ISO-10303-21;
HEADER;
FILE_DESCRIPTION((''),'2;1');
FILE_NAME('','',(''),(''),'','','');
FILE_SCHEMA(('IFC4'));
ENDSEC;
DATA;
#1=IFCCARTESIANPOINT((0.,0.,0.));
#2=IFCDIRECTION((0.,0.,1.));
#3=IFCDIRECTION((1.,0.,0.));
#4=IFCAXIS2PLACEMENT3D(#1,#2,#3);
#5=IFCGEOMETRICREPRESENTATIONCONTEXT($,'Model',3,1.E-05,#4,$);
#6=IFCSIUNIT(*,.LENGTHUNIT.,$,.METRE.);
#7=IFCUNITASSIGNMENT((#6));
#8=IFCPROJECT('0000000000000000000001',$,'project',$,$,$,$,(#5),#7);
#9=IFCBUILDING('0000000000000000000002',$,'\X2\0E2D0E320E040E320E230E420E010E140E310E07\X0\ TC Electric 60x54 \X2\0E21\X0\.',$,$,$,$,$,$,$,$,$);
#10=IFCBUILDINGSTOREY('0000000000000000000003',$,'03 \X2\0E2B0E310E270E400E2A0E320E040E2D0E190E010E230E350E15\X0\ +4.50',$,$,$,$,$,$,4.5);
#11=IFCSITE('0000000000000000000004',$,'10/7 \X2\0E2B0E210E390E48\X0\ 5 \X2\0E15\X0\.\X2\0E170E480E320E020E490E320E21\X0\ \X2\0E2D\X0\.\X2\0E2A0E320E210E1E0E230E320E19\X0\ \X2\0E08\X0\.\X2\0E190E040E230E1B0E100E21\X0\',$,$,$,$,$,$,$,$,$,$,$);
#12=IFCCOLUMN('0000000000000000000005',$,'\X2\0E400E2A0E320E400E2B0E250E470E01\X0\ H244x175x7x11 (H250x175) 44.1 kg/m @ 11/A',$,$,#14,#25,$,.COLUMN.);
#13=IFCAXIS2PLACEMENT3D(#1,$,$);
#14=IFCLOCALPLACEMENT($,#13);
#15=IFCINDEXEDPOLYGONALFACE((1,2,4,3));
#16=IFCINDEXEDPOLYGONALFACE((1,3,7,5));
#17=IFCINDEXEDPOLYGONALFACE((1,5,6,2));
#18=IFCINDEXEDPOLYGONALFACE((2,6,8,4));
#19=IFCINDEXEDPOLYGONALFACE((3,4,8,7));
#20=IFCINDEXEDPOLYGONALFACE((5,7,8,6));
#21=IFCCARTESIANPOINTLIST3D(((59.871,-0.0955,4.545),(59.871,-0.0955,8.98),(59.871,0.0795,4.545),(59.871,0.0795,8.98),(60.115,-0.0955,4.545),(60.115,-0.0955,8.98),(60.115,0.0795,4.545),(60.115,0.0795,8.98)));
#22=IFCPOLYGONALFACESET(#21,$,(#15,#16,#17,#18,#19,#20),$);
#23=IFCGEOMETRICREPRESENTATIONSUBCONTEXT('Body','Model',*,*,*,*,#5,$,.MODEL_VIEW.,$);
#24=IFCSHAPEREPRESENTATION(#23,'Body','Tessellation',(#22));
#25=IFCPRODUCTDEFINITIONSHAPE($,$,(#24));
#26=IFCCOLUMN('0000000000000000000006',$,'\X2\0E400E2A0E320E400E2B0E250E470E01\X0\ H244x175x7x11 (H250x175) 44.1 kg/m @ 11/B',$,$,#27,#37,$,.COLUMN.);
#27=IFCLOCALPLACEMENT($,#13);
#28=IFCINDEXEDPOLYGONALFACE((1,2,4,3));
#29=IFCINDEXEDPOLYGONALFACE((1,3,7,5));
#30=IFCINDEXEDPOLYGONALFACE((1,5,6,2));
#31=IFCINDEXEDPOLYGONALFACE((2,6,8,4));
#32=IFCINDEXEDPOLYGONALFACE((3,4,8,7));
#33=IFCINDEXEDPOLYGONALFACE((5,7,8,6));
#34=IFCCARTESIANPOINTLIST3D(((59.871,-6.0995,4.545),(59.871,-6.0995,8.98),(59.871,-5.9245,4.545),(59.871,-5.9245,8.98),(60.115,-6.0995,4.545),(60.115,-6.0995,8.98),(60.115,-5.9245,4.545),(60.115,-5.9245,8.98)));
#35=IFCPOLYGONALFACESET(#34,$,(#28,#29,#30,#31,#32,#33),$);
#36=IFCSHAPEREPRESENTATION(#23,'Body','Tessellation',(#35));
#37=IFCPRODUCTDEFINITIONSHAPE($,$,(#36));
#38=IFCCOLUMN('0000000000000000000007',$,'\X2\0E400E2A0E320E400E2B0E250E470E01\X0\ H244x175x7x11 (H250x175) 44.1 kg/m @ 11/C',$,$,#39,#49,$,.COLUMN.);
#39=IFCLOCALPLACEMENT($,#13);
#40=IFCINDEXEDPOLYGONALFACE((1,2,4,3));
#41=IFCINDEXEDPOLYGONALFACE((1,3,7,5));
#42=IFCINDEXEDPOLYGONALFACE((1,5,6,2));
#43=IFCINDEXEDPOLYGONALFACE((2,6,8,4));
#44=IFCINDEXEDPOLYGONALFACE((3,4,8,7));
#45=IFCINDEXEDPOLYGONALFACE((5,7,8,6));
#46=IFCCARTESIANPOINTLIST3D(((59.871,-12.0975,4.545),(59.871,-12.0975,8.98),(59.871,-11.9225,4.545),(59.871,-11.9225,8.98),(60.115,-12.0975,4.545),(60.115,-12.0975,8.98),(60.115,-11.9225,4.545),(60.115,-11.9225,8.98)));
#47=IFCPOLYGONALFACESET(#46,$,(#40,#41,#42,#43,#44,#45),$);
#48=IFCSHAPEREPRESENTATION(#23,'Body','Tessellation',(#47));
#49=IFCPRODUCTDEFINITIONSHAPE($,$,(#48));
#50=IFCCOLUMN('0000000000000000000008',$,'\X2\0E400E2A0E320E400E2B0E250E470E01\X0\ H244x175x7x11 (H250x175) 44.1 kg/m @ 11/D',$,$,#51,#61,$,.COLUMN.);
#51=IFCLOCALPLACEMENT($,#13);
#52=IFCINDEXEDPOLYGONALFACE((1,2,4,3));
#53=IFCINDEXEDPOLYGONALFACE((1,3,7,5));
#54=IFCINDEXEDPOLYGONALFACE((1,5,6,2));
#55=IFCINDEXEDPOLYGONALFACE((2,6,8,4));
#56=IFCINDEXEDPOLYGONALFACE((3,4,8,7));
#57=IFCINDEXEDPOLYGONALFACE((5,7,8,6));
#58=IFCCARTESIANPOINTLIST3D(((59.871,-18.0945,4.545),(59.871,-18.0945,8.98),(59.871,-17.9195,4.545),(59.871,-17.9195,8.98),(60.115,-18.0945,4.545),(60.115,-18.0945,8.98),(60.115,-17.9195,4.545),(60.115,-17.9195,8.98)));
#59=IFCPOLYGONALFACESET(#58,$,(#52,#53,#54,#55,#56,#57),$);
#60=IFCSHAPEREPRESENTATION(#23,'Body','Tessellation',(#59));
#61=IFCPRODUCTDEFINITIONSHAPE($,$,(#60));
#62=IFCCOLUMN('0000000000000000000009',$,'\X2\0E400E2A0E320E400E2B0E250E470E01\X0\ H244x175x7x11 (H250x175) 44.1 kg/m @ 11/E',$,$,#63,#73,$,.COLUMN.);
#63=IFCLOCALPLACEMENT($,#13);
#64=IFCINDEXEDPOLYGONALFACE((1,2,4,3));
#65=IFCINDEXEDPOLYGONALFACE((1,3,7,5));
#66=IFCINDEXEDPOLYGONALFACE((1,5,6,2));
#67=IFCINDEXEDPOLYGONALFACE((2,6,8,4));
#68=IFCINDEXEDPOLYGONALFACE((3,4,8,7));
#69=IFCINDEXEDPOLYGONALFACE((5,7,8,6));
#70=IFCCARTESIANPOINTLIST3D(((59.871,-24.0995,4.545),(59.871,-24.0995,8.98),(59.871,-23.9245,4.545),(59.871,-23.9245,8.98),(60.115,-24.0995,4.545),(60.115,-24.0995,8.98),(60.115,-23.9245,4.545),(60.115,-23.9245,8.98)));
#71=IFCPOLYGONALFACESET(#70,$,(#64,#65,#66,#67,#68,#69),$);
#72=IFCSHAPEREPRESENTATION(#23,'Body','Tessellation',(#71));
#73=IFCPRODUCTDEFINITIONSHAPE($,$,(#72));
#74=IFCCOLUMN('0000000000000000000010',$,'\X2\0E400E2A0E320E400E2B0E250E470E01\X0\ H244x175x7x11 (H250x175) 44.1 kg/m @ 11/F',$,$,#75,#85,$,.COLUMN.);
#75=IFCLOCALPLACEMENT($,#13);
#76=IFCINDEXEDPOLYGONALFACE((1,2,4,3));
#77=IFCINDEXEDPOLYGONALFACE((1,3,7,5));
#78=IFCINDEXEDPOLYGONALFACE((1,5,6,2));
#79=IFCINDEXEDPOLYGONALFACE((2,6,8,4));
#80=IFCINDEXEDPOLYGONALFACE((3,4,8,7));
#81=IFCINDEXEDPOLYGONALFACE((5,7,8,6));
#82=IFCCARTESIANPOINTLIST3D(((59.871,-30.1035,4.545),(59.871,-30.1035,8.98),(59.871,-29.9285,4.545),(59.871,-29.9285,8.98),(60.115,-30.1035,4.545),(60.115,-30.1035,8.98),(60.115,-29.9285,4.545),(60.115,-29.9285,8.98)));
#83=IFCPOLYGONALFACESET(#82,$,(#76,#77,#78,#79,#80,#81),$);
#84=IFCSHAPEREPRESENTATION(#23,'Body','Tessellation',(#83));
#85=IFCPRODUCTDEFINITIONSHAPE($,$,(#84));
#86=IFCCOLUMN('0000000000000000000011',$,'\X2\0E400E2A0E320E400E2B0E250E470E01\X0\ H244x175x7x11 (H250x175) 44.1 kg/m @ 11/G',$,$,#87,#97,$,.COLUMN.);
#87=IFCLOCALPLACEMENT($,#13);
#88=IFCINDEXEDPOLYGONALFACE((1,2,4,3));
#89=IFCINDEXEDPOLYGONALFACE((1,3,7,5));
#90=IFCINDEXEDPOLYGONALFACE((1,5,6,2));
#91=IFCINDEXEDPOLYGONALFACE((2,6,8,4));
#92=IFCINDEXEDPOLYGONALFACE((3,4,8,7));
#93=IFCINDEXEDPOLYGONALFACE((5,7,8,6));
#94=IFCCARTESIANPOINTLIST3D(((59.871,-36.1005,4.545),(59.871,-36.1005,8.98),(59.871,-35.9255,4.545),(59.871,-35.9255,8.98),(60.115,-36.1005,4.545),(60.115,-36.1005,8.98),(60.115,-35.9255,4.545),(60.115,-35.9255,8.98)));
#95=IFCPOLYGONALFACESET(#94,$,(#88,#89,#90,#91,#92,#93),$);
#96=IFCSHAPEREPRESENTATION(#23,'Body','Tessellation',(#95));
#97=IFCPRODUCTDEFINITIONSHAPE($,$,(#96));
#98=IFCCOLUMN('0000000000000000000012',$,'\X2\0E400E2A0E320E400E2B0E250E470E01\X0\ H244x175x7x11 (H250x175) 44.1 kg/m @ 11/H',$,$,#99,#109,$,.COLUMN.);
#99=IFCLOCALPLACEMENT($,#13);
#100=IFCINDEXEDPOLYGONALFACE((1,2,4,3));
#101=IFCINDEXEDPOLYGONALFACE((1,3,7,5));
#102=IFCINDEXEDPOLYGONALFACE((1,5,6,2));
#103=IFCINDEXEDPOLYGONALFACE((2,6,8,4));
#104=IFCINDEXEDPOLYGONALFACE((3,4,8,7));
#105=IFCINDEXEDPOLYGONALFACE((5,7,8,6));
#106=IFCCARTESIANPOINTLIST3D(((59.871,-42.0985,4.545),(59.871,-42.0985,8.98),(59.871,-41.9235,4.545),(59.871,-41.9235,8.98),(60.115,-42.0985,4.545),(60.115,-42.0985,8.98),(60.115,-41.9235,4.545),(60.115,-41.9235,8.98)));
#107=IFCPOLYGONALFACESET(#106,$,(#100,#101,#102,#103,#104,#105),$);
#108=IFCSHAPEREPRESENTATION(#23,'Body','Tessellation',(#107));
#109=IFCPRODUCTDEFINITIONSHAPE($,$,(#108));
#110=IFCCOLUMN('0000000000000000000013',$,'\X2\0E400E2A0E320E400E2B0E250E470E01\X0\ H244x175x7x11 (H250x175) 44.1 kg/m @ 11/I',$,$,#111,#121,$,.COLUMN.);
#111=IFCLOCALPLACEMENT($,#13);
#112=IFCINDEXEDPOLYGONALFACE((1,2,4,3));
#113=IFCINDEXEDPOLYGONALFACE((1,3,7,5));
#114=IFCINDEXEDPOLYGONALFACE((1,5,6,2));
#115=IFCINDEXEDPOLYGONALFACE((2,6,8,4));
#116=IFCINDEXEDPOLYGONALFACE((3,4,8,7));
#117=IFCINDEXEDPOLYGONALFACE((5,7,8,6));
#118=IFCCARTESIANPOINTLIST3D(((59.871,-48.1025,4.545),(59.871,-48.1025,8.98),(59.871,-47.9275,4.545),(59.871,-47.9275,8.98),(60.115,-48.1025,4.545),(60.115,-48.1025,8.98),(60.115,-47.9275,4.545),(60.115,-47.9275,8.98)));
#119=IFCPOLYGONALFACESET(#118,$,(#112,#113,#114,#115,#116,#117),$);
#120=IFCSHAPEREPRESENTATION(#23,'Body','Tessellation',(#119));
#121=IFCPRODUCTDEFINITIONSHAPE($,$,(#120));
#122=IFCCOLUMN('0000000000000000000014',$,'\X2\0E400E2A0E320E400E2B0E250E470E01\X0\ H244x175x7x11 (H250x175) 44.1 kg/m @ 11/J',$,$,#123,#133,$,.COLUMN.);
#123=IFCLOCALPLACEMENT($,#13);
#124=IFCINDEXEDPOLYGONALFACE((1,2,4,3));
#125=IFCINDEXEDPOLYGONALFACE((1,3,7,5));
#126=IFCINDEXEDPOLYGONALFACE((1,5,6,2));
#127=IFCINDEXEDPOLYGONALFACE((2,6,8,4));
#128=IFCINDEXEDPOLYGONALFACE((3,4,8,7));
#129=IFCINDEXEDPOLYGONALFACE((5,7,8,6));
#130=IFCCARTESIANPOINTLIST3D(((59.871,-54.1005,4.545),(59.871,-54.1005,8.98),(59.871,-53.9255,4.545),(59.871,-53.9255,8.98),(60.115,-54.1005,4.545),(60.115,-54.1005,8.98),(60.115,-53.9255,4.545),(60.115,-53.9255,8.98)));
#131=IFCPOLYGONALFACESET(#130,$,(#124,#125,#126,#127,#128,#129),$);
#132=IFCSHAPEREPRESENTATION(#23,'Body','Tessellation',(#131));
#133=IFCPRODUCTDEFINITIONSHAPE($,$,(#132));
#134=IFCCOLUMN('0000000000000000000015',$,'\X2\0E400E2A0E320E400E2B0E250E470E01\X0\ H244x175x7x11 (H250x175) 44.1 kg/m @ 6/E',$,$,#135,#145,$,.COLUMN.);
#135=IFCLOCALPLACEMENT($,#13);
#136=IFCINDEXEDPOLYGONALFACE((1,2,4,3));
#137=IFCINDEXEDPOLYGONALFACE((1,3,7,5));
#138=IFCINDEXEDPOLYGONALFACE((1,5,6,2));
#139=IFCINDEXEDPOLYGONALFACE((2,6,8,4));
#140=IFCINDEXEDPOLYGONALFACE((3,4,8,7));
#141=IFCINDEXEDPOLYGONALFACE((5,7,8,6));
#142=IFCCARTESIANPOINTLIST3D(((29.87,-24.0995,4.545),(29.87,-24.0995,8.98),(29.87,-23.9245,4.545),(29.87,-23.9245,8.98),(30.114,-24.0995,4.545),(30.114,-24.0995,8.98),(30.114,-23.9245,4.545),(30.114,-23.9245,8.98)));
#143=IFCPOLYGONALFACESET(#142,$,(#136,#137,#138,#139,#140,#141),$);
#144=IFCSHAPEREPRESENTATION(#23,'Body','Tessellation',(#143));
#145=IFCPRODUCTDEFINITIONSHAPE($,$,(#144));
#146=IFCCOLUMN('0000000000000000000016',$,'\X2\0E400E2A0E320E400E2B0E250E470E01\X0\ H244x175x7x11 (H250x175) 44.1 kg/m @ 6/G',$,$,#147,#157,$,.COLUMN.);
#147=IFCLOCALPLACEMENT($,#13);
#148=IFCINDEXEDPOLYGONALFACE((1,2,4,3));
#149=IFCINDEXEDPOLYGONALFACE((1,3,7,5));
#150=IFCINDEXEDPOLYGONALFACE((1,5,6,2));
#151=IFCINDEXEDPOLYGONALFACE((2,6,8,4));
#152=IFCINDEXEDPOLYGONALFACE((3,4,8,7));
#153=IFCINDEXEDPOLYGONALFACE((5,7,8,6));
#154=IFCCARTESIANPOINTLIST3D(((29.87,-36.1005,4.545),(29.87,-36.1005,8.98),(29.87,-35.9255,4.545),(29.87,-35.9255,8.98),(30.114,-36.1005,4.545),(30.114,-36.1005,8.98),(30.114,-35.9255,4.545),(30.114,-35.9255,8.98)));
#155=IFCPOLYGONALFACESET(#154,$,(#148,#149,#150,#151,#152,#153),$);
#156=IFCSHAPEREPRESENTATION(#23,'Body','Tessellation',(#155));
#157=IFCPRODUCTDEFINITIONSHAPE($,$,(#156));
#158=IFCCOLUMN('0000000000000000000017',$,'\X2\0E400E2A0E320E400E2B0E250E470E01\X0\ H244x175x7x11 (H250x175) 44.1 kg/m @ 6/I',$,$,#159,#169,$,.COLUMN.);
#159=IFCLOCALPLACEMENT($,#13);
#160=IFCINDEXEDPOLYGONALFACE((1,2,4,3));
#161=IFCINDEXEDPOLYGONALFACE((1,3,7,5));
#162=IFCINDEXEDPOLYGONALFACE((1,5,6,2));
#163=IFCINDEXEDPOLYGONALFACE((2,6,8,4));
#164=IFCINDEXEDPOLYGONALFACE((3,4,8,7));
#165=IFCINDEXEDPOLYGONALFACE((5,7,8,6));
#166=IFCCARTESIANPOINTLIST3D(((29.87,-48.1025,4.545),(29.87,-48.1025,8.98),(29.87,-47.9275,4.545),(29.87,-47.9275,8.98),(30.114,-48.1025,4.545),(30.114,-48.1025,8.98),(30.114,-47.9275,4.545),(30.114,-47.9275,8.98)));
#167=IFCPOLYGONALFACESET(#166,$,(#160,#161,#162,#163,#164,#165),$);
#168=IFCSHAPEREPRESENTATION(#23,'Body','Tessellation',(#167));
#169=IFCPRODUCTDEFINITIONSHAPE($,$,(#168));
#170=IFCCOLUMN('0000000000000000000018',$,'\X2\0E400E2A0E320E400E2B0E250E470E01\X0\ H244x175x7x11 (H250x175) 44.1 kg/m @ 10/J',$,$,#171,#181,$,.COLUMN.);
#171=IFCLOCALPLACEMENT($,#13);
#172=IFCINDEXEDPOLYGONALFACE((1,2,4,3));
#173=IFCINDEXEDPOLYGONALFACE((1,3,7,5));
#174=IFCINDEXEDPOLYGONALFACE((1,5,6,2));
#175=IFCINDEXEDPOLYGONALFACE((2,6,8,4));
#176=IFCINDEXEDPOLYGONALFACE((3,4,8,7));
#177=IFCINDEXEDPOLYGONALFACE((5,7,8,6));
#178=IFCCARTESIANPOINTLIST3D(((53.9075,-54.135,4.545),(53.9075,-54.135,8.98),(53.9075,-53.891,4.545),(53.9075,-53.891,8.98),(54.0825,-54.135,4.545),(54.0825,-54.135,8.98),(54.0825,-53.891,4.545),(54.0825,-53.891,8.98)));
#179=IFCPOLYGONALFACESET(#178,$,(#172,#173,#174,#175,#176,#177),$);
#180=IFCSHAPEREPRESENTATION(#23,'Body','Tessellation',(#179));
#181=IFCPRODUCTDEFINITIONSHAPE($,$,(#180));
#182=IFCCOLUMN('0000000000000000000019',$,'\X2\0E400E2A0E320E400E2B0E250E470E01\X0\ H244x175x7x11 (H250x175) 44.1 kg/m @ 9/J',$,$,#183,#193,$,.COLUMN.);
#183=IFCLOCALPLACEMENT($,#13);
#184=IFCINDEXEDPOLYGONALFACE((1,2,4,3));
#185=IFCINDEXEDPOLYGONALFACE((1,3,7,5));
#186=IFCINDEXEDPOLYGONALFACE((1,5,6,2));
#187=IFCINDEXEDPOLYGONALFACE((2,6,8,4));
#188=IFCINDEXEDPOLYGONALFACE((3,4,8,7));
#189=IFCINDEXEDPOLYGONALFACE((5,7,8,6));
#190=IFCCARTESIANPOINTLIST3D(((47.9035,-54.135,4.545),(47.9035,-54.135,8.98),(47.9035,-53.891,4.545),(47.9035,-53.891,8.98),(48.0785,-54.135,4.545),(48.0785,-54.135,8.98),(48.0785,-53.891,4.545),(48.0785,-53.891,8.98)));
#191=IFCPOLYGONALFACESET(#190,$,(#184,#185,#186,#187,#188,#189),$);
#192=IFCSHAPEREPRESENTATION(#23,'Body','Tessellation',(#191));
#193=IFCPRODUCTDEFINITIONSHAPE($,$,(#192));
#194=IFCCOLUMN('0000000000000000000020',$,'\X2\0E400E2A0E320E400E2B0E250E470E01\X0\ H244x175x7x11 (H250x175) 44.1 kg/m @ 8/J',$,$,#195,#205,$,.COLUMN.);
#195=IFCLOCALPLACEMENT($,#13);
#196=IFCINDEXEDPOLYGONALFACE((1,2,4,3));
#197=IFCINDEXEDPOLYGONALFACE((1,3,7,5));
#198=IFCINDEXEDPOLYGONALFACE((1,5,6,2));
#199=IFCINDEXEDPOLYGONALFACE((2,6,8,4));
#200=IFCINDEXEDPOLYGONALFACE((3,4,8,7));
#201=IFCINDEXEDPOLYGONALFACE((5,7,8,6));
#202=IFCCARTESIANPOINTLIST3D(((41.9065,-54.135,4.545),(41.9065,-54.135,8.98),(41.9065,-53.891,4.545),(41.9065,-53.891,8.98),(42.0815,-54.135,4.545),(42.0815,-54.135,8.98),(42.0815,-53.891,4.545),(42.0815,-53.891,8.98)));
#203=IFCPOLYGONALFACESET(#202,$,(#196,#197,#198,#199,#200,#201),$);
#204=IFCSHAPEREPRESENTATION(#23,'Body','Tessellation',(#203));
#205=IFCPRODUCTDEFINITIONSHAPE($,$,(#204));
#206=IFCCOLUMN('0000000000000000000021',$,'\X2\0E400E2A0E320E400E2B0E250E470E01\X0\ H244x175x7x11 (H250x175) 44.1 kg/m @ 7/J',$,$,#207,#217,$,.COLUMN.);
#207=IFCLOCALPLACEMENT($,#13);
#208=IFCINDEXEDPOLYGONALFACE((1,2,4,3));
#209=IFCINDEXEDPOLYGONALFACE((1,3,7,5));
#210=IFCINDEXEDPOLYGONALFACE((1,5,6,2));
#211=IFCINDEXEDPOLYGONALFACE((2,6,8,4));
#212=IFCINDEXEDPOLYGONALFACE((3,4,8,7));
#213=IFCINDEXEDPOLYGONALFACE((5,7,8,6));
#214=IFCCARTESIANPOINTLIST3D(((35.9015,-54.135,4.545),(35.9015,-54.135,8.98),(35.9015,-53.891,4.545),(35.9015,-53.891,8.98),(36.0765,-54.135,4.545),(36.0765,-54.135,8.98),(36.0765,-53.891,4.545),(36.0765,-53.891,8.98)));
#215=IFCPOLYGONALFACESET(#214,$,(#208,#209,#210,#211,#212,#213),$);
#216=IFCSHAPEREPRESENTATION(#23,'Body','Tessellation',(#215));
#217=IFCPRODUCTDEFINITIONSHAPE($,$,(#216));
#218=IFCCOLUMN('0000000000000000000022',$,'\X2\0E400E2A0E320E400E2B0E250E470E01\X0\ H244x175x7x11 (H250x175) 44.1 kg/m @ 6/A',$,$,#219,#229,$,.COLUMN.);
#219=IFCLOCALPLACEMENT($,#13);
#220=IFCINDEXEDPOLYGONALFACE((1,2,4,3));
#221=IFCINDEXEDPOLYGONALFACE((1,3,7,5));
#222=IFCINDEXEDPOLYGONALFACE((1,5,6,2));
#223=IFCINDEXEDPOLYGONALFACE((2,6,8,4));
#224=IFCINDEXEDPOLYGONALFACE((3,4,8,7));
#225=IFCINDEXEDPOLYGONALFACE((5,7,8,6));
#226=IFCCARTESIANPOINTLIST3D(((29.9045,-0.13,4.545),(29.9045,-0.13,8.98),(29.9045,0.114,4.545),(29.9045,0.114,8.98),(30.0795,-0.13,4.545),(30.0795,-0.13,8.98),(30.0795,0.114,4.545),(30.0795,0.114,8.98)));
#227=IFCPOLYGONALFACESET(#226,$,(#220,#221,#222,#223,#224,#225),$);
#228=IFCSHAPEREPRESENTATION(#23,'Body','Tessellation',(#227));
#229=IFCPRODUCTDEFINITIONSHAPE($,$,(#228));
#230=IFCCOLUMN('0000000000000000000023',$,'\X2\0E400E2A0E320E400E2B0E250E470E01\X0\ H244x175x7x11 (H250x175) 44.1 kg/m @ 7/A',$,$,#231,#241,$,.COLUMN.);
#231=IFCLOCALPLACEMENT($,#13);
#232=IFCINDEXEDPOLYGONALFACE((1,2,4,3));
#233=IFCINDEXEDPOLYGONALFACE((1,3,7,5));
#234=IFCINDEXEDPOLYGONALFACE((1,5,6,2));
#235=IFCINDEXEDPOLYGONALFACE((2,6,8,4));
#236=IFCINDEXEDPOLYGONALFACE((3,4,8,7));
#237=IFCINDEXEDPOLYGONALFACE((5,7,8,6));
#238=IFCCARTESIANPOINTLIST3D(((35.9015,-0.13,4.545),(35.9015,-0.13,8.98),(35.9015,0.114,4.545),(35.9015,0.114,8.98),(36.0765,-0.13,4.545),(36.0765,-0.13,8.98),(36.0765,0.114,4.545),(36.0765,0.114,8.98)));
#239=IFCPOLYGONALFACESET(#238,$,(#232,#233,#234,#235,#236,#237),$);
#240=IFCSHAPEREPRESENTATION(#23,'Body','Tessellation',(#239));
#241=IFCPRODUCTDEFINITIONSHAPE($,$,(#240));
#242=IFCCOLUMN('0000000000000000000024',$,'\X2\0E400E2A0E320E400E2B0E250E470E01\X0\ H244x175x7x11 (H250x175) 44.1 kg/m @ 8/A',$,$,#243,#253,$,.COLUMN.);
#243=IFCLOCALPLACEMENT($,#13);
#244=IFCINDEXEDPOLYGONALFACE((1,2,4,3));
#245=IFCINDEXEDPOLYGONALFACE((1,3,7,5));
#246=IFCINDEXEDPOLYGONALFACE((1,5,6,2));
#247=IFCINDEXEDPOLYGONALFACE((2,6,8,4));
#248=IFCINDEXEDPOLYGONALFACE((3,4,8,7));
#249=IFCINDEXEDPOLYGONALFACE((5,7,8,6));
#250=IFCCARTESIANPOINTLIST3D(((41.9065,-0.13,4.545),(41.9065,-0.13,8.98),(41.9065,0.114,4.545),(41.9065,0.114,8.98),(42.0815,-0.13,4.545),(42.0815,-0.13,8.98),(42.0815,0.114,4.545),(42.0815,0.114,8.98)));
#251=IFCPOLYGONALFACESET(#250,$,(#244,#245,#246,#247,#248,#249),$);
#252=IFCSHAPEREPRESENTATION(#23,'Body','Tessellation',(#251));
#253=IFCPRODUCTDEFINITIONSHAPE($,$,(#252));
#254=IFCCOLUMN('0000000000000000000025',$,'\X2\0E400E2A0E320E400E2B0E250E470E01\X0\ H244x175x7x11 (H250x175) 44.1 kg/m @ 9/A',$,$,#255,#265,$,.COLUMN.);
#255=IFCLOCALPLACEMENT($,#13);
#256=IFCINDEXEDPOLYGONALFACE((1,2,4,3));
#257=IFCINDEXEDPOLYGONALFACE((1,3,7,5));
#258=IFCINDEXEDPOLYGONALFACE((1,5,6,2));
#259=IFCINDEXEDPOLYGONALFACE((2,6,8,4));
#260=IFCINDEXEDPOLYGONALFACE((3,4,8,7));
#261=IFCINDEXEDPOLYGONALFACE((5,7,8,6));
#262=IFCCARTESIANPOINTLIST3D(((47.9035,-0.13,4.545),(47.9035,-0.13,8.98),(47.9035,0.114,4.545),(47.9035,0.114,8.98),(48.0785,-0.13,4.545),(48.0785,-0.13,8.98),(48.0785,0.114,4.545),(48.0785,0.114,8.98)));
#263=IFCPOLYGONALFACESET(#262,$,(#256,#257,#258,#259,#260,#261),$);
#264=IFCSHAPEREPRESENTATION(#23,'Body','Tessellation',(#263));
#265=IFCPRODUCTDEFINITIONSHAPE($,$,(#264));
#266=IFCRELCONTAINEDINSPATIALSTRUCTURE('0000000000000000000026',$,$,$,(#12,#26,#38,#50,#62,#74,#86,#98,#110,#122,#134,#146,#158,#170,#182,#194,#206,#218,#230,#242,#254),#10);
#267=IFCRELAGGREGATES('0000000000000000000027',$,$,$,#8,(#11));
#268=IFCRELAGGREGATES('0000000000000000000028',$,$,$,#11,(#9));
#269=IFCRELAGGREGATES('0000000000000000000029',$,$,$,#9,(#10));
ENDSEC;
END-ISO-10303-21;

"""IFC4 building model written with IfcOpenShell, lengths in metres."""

from ifc_helpers import new_model, si_unit, frame, origin, origin_with_axes, origin_2d, place, context, subcontext, project, spatial, rectangle, extrude, element, save


model = new_model("IFC4")

# Units and contexts
model_context = context("Model", 3, precision=1e-05, world=origin_with_axes())
body_context = subcontext(model_context, "Body", "Model", "MODEL_VIEW")
ifc_project = project(units=[si_unit("LENGTHUNIT", "METRE")], contexts=[model_context])

# Site, building, storey
site = spatial("IfcSite", under=ifc_project, Name="10/7 หมู่ 5 ต.ท่าข้าม อ.สามพราน จ.นครปฐม")
building = spatial("IfcBuilding", under=site, Name="อาคารโกดัง TC Electric 60x54 ม.")
storey = spatial("IfcBuildingStorey", under=building, Name="03 หัวเสาคอนกรีต +4.50", Elevation=4.5)

# Columns
for number, where, z_axis, x_axis, name in (
    (1, (59.993, -0.008, 4.545), (0.0, 0.0, 1.0), (1.0, 0.0, 0.0), "เสาเหล็ก H244x175x7x11 (H250x175) 44.1 kg/m @ 11/A"),
    (2, (59.993, -6.012, 4.545), (0.0, 0.0, 1.0), (1.0, 0.0, 0.0), "เสาเหล็ก H244x175x7x11 (H250x175) 44.1 kg/m @ 11/B"),
    (3, (59.993, -12.01, 4.545), (0.0, 0.0, 1.0), (1.0, 0.0, 0.0), "เสาเหล็ก H244x175x7x11 (H250x175) 44.1 kg/m @ 11/C"),
    (4, (59.993, -18.007, 4.545), (0.0, 0.0, 1.0), (1.0, 0.0, 0.0), "เสาเหล็ก H244x175x7x11 (H250x175) 44.1 kg/m @ 11/D"),
    (5, (59.993, -24.012, 4.545), (0.0, 0.0, 1.0), (1.0, 0.0, 0.0), "เสาเหล็ก H244x175x7x11 (H250x175) 44.1 kg/m @ 11/E"),
    (6, (59.993, -30.016, 4.545), (0.0, 0.0, 1.0), (1.0, 0.0, 0.0), "เสาเหล็ก H244x175x7x11 (H250x175) 44.1 kg/m @ 11/F"),
    (7, (59.993, -36.013, 4.545), (0.0, 0.0, 1.0), (1.0, 0.0, 0.0), "เสาเหล็ก H244x175x7x11 (H250x175) 44.1 kg/m @ 11/G"),
    (8, (59.993, -42.011, 4.545), (0.0, 0.0, 1.0), (1.0, 0.0, 0.0), "เสาเหล็ก H244x175x7x11 (H250x175) 44.1 kg/m @ 11/H"),
    (9, (59.993, -48.015, 4.545), (0.0, 0.0, 1.0), (1.0, 0.0, 0.0), "เสาเหล็ก H244x175x7x11 (H250x175) 44.1 kg/m @ 11/I"),
    (10, (59.993, -54.013, 4.545), (0.0, 0.0, 1.0), (1.0, 0.0, 0.0), "เสาเหล็ก H244x175x7x11 (H250x175) 44.1 kg/m @ 11/J"),
    (11, (29.992, -24.012, 4.545), (0.0, 0.0, 1.0), (1.0, 0.0, 0.0), "เสาเหล็ก H244x175x7x11 (H250x175) 44.1 kg/m @ 6/E"),
    (12, (29.992, -36.013, 4.545), (0.0, 0.0, 1.0), (1.0, 0.0, 0.0), "เสาเหล็ก H244x175x7x11 (H250x175) 44.1 kg/m @ 6/G"),
    (13, (29.992, -48.015, 4.545), (0.0, 0.0, 1.0), (1.0, 0.0, 0.0), "เสาเหล็ก H244x175x7x11 (H250x175) 44.1 kg/m @ 6/I"),
):
    element("IfcColumn", number, at=place(None, frame(where, z_axis=z_axis, x_axis=x_axis)), inside=storey, Name=name, PredefinedType="COLUMN", context=body_context, shape_type="SweptSolid", body=[
        extrude(rectangle(XDim=0.244, YDim=0.175, at=origin_2d()), origin(), (0.0, 0.0, 1.0), 4.435),
    ])
for number, where, z_axis, x_axis, name in (
    (14, (53.995, -54.013, 4.545), (0.0, 0.0, 1.0), (1.0, 0.0, 0.0), "เสาเหล็ก H244x175x7x11 (H250x175) 44.1 kg/m @ 10/J"),
    (15, (47.991, -54.013, 4.545), (0.0, 0.0, 1.0), (1.0, 0.0, 0.0), "เสาเหล็ก H244x175x7x11 (H250x175) 44.1 kg/m @ 9/J"),
    (16, (41.994, -54.013, 4.545), (0.0, 0.0, 1.0), (1.0, 0.0, 0.0), "เสาเหล็ก H244x175x7x11 (H250x175) 44.1 kg/m @ 8/J"),
    (17, (35.989, -54.013, 4.545), (0.0, 0.0, 1.0), (1.0, 0.0, 0.0), "เสาเหล็ก H244x175x7x11 (H250x175) 44.1 kg/m @ 7/J"),
    (18, (29.992, -0.008, 4.545), (0.0, 0.0, 1.0), (1.0, 0.0, 0.0), "เสาเหล็ก H244x175x7x11 (H250x175) 44.1 kg/m @ 6/A"),
    (19, (35.989, -0.008, 4.545), (0.0, 0.0, 1.0), (1.0, 0.0, 0.0), "เสาเหล็ก H244x175x7x11 (H250x175) 44.1 kg/m @ 7/A"),
    (20, (41.994, -0.008, 4.545), (0.0, 0.0, 1.0), (1.0, 0.0, 0.0), "เสาเหล็ก H244x175x7x11 (H250x175) 44.1 kg/m @ 8/A"),
    (21, (47.991, -0.008, 4.545), (0.0, 0.0, 1.0), (1.0, 0.0, 0.0), "เสาเหล็ก H244x175x7x11 (H250x175) 44.1 kg/m @ 9/A"),
):
    element("IfcColumn", number, at=place(None, frame(where, z_axis=z_axis, x_axis=x_axis)), inside=storey, Name=name, PredefinedType="COLUMN", context=body_context, shape_type="SweptSolid", body=[
        extrude(rectangle(XDim=0.175, YDim=0.244, at=origin_2d()), origin(), (0.0, 0.0, 1.0), 4.435),
    ])

save(model, "model.ifc")
